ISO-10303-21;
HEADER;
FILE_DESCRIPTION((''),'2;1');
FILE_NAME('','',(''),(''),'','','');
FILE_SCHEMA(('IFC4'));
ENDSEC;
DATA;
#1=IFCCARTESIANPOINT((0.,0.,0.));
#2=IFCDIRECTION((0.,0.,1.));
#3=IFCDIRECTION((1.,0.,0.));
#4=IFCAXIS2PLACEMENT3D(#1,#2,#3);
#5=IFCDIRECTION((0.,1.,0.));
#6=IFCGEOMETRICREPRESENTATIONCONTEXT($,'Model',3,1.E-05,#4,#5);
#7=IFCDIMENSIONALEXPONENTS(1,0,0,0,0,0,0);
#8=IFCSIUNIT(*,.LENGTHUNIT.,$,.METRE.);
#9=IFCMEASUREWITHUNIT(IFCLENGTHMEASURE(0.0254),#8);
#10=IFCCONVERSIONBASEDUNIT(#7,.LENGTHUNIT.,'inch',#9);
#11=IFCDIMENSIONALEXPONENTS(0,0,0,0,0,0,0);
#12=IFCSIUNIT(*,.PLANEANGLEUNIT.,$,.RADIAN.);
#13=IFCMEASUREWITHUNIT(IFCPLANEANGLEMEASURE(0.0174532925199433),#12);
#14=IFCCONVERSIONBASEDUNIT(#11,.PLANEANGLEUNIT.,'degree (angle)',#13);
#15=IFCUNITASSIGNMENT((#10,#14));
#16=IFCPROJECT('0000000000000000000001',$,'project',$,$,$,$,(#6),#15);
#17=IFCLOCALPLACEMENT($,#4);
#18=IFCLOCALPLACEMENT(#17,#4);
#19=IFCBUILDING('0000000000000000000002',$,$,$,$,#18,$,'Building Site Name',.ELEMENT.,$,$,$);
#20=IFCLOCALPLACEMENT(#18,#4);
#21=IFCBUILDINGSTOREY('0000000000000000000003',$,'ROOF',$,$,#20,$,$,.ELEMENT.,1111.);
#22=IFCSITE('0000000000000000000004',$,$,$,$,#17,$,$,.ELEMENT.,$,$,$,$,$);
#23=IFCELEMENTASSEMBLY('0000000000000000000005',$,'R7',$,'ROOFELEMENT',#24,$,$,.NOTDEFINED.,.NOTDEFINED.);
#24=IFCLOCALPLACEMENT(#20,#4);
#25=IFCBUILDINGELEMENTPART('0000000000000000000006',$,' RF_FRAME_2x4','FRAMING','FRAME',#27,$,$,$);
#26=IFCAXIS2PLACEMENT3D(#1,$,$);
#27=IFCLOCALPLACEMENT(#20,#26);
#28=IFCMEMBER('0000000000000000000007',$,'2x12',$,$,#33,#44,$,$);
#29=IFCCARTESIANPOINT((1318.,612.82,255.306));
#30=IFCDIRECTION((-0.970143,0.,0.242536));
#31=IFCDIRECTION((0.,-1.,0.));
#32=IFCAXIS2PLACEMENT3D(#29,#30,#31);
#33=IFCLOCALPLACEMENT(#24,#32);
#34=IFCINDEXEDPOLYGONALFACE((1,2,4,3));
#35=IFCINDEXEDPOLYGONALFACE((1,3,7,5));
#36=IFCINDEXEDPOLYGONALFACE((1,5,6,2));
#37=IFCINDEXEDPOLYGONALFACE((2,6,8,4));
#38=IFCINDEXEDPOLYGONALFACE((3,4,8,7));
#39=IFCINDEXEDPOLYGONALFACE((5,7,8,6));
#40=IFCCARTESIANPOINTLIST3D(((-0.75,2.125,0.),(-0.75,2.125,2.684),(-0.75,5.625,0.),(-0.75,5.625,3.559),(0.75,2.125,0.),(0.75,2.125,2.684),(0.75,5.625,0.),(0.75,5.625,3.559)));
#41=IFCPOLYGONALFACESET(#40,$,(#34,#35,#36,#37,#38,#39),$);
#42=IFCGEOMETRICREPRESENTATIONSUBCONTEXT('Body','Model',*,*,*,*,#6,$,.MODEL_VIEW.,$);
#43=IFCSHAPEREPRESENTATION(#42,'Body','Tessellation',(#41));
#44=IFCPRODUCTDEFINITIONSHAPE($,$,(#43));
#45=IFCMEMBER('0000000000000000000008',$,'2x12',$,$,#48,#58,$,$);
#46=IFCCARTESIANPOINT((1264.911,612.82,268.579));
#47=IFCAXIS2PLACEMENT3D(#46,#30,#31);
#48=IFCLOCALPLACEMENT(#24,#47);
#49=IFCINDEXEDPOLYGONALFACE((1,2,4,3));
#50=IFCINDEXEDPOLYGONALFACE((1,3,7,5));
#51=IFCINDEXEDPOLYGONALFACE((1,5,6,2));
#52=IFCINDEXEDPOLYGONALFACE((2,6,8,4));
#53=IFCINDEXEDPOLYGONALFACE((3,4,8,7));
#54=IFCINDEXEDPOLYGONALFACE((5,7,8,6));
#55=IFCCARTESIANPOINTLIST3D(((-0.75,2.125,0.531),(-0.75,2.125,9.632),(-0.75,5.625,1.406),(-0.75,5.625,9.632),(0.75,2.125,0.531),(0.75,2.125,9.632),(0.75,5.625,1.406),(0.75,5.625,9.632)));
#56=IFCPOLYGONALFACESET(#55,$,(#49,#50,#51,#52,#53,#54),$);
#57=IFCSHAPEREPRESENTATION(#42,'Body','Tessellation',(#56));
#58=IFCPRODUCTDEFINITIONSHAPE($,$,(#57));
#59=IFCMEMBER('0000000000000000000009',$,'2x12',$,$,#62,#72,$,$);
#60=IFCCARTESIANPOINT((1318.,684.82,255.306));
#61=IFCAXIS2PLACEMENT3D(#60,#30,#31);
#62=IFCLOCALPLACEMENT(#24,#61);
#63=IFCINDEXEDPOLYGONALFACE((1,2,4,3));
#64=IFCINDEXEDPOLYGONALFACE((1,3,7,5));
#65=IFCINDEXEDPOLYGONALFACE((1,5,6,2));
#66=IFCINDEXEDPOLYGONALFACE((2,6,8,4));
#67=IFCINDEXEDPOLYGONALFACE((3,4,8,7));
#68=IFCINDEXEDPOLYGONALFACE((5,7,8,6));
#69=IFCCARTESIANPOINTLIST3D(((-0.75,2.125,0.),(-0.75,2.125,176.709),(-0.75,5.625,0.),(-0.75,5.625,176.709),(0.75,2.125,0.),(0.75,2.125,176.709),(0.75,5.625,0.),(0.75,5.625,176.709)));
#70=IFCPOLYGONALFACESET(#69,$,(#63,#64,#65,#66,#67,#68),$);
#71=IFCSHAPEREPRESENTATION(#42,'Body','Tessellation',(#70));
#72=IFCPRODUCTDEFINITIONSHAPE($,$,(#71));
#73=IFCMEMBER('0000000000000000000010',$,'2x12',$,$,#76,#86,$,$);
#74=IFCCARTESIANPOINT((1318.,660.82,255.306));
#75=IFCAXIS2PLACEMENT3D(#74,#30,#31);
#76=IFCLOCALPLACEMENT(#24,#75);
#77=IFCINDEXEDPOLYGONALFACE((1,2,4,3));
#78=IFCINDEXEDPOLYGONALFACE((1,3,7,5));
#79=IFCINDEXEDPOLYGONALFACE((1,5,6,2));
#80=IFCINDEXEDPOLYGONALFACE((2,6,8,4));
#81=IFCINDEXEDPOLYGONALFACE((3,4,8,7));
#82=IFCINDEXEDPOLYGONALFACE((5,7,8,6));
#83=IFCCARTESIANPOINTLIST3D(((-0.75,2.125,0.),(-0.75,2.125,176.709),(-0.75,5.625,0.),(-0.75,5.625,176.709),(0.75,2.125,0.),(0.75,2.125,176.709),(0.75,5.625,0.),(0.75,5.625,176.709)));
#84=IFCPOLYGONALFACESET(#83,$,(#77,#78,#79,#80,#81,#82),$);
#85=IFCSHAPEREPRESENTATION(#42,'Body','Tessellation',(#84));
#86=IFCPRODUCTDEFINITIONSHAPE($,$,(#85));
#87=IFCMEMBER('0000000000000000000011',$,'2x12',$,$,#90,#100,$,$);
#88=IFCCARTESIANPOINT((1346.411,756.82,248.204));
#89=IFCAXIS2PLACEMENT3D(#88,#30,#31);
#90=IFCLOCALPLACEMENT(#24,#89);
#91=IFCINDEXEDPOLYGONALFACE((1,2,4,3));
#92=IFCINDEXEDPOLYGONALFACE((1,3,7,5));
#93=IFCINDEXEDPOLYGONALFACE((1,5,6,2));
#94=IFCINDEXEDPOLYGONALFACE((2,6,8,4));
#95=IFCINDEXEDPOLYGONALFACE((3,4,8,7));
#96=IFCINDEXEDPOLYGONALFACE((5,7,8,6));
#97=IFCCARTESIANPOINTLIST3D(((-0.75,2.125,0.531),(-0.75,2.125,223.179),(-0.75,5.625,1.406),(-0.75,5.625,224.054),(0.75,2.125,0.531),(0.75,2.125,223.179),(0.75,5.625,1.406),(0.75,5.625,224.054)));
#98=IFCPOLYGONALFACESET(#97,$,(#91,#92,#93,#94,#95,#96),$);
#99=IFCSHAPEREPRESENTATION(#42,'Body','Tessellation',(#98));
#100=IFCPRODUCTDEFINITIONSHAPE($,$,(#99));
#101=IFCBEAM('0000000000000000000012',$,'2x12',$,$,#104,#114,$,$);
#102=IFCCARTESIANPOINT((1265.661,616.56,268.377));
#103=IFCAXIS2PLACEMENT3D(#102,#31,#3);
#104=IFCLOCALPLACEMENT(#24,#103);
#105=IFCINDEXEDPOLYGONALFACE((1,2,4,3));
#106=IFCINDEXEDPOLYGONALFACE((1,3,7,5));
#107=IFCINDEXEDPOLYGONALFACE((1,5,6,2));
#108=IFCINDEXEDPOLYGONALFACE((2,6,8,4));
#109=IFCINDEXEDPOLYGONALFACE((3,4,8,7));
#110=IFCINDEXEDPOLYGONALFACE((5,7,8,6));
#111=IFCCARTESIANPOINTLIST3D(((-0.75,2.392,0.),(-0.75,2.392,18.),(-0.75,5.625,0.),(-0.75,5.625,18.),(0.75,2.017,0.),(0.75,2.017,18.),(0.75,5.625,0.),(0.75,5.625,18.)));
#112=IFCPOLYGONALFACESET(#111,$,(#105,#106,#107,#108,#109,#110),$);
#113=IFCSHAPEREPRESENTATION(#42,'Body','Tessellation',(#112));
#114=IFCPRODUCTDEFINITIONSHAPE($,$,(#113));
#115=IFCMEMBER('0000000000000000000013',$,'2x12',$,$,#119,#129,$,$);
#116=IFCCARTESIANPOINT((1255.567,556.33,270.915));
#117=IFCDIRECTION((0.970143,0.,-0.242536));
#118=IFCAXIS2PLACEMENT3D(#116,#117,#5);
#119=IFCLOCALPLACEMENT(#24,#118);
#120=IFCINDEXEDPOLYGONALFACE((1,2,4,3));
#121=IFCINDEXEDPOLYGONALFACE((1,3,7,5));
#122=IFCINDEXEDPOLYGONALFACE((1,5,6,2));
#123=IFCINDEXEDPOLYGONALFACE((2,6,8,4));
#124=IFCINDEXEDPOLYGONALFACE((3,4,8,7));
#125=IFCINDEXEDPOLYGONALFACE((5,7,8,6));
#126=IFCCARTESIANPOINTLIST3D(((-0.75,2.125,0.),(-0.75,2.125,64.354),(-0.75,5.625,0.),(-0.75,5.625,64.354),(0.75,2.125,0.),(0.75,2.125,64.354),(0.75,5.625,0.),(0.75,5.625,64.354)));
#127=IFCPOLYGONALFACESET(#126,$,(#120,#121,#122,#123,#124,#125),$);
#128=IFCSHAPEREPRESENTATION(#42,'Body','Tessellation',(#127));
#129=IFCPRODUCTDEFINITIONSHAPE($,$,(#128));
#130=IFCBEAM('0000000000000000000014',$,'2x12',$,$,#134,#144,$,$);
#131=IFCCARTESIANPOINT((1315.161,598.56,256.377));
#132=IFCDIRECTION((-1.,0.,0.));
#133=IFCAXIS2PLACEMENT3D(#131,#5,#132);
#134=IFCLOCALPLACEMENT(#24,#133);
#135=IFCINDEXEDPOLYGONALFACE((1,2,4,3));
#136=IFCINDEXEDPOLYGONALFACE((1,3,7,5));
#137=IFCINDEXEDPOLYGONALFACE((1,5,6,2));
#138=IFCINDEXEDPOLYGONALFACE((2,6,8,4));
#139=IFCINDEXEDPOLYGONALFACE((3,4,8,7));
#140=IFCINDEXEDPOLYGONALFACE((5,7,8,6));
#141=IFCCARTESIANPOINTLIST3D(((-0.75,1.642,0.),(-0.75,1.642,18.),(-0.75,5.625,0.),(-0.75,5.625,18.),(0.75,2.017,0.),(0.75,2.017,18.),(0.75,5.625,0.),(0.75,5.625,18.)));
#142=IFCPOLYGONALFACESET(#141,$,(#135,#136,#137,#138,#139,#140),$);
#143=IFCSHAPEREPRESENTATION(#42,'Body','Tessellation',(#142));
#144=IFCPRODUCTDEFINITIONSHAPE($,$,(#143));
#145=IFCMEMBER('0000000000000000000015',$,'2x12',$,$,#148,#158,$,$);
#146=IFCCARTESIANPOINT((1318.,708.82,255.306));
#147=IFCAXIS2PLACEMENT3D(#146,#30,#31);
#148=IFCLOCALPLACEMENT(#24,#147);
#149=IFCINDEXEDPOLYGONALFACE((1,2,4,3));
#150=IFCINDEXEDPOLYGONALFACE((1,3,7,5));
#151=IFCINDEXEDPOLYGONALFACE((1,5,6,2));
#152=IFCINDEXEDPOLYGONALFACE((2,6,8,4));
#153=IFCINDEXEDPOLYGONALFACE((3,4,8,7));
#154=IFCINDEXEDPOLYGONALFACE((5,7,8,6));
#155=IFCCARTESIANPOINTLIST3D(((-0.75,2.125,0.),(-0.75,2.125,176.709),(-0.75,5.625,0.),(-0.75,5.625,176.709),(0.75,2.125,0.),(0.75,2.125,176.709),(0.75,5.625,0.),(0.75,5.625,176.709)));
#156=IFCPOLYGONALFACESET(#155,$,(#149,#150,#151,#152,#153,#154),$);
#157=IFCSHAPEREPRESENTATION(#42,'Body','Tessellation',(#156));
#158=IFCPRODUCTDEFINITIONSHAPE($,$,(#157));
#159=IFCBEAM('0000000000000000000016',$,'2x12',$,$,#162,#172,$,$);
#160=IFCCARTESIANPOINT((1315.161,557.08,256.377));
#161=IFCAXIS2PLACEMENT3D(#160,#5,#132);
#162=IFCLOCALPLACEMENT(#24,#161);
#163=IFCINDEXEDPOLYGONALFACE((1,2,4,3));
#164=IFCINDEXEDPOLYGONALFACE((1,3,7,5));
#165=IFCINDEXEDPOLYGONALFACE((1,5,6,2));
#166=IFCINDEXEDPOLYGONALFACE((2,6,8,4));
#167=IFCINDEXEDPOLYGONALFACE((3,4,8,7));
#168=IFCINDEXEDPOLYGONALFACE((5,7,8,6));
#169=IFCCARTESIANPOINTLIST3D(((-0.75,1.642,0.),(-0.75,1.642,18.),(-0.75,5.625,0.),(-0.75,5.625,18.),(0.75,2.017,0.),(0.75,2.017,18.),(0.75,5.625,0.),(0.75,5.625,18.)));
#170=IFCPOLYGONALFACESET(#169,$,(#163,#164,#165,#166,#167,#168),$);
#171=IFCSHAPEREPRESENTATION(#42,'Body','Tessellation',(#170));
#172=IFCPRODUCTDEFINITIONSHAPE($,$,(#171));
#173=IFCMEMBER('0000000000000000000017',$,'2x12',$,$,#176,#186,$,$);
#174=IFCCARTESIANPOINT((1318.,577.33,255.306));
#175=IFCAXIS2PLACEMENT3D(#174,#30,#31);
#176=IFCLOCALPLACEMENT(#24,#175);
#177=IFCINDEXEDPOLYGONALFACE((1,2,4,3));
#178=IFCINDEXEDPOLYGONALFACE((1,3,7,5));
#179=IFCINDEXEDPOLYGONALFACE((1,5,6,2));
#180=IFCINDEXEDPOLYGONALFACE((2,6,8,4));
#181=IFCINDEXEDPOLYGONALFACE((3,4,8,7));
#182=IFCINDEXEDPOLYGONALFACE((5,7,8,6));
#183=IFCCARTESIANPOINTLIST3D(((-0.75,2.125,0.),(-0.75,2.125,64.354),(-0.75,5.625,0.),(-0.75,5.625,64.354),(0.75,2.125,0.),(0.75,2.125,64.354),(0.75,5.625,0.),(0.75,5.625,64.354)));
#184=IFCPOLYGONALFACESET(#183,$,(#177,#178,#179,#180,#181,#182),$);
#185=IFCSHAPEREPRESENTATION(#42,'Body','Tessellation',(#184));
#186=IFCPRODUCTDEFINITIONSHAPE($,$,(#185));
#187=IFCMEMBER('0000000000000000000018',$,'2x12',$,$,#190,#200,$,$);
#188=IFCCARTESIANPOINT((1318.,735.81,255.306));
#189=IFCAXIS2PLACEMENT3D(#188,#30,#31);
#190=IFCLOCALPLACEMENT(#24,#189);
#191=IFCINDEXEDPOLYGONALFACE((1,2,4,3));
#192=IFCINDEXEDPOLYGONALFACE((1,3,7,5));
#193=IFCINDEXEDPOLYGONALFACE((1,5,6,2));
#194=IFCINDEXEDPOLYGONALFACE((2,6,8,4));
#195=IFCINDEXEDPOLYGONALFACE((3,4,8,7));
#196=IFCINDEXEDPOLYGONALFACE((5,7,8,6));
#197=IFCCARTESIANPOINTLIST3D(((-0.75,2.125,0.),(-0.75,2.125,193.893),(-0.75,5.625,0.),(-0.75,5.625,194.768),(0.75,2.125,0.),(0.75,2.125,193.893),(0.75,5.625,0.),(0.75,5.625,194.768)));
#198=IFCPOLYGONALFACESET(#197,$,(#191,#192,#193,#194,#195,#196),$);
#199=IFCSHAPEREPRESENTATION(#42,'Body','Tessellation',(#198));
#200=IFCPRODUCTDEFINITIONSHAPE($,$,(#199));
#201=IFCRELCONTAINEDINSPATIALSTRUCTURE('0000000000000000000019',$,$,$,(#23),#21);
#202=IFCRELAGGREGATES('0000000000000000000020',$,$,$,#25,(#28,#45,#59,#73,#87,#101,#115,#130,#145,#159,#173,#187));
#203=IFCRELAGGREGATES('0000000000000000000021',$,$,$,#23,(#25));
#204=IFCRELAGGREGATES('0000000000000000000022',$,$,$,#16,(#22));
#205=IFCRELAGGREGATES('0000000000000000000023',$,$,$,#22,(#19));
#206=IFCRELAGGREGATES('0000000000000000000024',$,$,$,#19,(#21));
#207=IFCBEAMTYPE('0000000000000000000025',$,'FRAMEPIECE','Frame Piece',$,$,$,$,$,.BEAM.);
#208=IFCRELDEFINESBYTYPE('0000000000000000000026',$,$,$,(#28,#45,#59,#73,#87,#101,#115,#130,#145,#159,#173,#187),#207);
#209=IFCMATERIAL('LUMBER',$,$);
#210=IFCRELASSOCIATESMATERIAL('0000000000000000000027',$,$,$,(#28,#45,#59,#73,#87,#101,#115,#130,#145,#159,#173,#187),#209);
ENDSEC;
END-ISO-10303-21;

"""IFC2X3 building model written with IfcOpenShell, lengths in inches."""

from ifc_helpers import new_model, entity, si_unit, converted_unit, direction, frame, frame_2d, origin_with_axes, place, context, subcontext, project, spatial, polyline, segment, composite_curve, rectangle, outline, extrude, clip, halfspace, material, type_object, element, aggregate, save


model = new_model("IFC2X3")

# Units and contexts
model_context = context("Model", 3, precision=1e-05, world=origin_with_axes(), true_north=direction((0.0, 1.0, 0.0)))
body_context = subcontext(model_context, "Body", "Model", "MODEL_VIEW")
ifc_project = project(units=[converted_unit("LENGTHUNIT", "inch", entity("IfcLengthMeasure", 0.0254), si_unit("LENGTHUNIT", "METRE"), dimensions=[1, 0, 0, 0, 0, 0, 0]), converted_unit("PLANEANGLEUNIT", "degree (angle)", entity("IfcPlaneAngleMeasure", 0.0174532925199433), si_unit("PLANEANGLEUNIT", "RADIAN"), dimensions=[0, 0, 0, 0, 0, 0, 0])], contexts=[model_context])

# Site, building, storey
site_placement = place(None, origin_with_axes())
site = spatial("IfcSite", under=ifc_project, at=site_placement, CompositionType="ELEMENT")
building_placement = place(site_placement, origin_with_axes())
building = spatial("IfcBuilding", under=site, at=building_placement, LongName="Building Site Name", CompositionType="ELEMENT")
storey_placement = place(building_placement, origin_with_axes())
storey = spatial("IfcBuildingStorey", under=building, at=storey_placement, Name="ROOF", CompositionType="ELEMENT", Elevation=1111.0)

# Element assembly, building element part, members, beams
assembly_placement = place(storey_placement, origin_with_axes())
assembly = element("IfcElementAssembly", 1, at=assembly_placement, inside=storey, Name="R7", ObjectType="ROOFELEMENT", AssemblyPlace="NOTDEFINED", PredefinedType="NOTDEFINED")
building_element_part_1 = element("IfcBuildingElementPart", 2, Name=" RF_FRAME_2x4", Description="FRAMING", ObjectType="FRAME")
ifc_material_1 = material(Name="LUMBER")
beam_type = type_object("IfcBeamType", Name="FRAMEPIECE", Description="Frame Piece", PredefinedType="BEAM")
member_1_placement = place(assembly_placement, frame((1318.0, 612.82, 255.306), z_axis=(-0.970143, 0.0, 0.242536), x_axis=(0.0, -1.0, 0.0)))
member_1 = element("IfcMember", 3, at=member_1_placement, type_object=beam_type, material=ifc_material_1, Name="2x12", context=body_context, shape_type="Clipping", body=[
    clip(extrude(rectangle(XDim=3.5, YDim=1.5, at=frame_2d((0.0, 3.875), x_axis=(0.0, -1.0))), frame((0.0, 0.0, 0.0), z_axis=(0.0, 0.0, 1.0), x_axis=(1.0, 0.0, 0.0)), (0.0, 0.0, 1.0), 5.338), halfspace(frame((-0.75, 2.125, 2.684), z_axis=(0.0, 0.242536, -0.970143), x_axis=(0.0, -0.970143, -0.242536)), True)),
])
member_2_placement = place(assembly_placement, frame((1264.911, 612.82, 268.579), z_axis=(-0.970143, 0.0, 0.242536), x_axis=(0.0, -1.0, 0.0)))
member_2 = element("IfcMember", 4, at=member_2_placement, type_object=beam_type, material=ifc_material_1, Name="2x12", context=body_context, shape_type="Clipping", body=[
    clip(extrude(rectangle(XDim=3.5, YDim=1.5, at=frame_2d((0.0, 3.875), x_axis=(0.0, -1.0))), frame((0.0, 0.0, -4.019), z_axis=(0.0, 0.0, 1.0), x_axis=(1.0, 0.0, 0.0)), (0.0, 0.0, 1.0), 13.651), halfspace(frame((0.75, 2.125, 0.531), z_axis=(0.0, -0.242536, 0.970143), x_axis=(0.0, 0.970143, 0.242536)), True)),
])
member_3_placement = place(assembly_placement, frame((1318.0, 684.82, 255.306), z_axis=(-0.970143, 0.0, 0.242536), x_axis=(0.0, -1.0, 0.0)))
member_3 = element("IfcMember", 5, at=member_3_placement, type_object=beam_type, material=ifc_material_1, Name="2x12", context=body_context, shape_type="SweptSolid", body=[
    extrude(rectangle(XDim=3.5, YDim=1.5, at=frame_2d((0.0, 3.875), x_axis=(0.0, -1.0))), frame((0.0, 0.0, 0.0), z_axis=(0.0, 0.0, 1.0), x_axis=(1.0, 0.0, 0.0)), (0.0, 0.0, 1.0), 176.709),
])
member_4_placement = place(assembly_placement, frame((1318.0, 660.82, 255.306), z_axis=(-0.970143, 0.0, 0.242536), x_axis=(0.0, -1.0, 0.0)))
member_4 = element("IfcMember", 6, at=member_4_placement, type_object=beam_type, material=ifc_material_1, Name="2x12", context=body_context, shape_type="SweptSolid", body=[
    extrude(rectangle(XDim=3.5, YDim=1.5, at=frame_2d((0.0, 3.875), x_axis=(0.0, -1.0))), frame((0.0, 0.0, 0.0), z_axis=(0.0, 0.0, 1.0), x_axis=(1.0, 0.0, 0.0)), (0.0, 0.0, 1.0), 176.709),
])
member_5_placement = place(assembly_placement, frame((1346.411, 756.82, 248.204), z_axis=(-0.970143, 0.0, 0.242536), x_axis=(0.0, -1.0, 0.0)))
member_5 = element("IfcMember", 7, at=member_5_placement, type_object=beam_type, material=ifc_material_1, Name="2x12", context=body_context, shape_type="Clipping", body=[
    clip(clip(extrude(rectangle(XDim=3.5, YDim=1.5, at=frame_2d((0.0, 3.875), x_axis=(0.0, -1.0))), frame((0.0, 0.0, -111.23), z_axis=(0.0, 0.0, 1.0), x_axis=(1.0, 0.0, 0.0)), (0.0, 0.0, 1.0), 447.045), halfspace(frame((0.75, 2.125, 0.531), z_axis=(0.0, -0.242536, 0.970143), x_axis=(0.0, 0.970143, 0.242536)), True)), halfspace(frame((-0.75, 2.125, 223.179), z_axis=(0.0, 0.242536, -0.970143), x_axis=(0.0, -0.970143, -0.242536)), True)),
])
beam_1_placement = place(assembly_placement, frame((1265.661, 616.56, 268.377), z_axis=(0.0, -1.0, 0.0), x_axis=(1.0, 0.0, 0.0)))
beam_1 = element("IfcBeam", 8, at=beam_1_placement, type_object=beam_type, material=ifc_material_1, Name="2x12", context=body_context, shape_type="SweptSolid", body=[
    extrude(outline(composite_curve([segment(polyline([(-0.75, 2.392), (0.75, 2.017), (0.75, 5.625), (-0.75, 5.625), (-0.75, 2.392)]), True, "CONTINUOUS")], self_intersect=False)), origin_with_axes(), (0.0, 0.0, 1.0), 18.0),
])
member_6_placement = place(assembly_placement, frame((1255.567, 556.33, 270.915), z_axis=(0.970143, 0.0, -0.242536), x_axis=(0.0, 1.0, 0.0)))
member_6 = element("IfcMember", 9, at=member_6_placement, type_object=beam_type, material=ifc_material_1, Name="2x12", context=body_context, shape_type="SweptSolid", body=[
    extrude(rectangle(XDim=3.5, YDim=1.5, at=frame_2d((0.0, 3.875), x_axis=(0.0, -1.0))), frame((0.0, 0.0, 0.0), z_axis=(0.0, 0.0, 1.0), x_axis=(1.0, 0.0, 0.0)), (0.0, 0.0, 1.0), 64.354),
])
beam_2_placement = place(assembly_placement, frame((1315.161, 598.56, 256.377), z_axis=(0.0, 1.0, 0.0), x_axis=(-1.0, 0.0, 0.0)))
beam_2 = element("IfcBeam", 10, at=beam_2_placement, type_object=beam_type, material=ifc_material_1, Name="2x12", context=body_context, shape_type="SweptSolid", body=[
    extrude(outline(composite_curve([segment(polyline([(-0.75, 1.642), (0.75, 2.017), (0.75, 5.625), (-0.75, 5.625), (-0.75, 1.642)]), True, "CONTINUOUS")], self_intersect=False)), origin_with_axes(), (0.0, 0.0, 1.0), 18.0),
])
member_7_placement = place(assembly_placement, frame((1318.0, 708.82, 255.306), z_axis=(-0.970143, 0.0, 0.242536), x_axis=(0.0, -1.0, 0.0)))
member_7 = element("IfcMember", 11, at=member_7_placement, type_object=beam_type, material=ifc_material_1, Name="2x12", context=body_context, shape_type="SweptSolid", body=[
    extrude(rectangle(XDim=3.5, YDim=1.5, at=frame_2d((0.0, 3.875), x_axis=(0.0, -1.0))), frame((0.0, 0.0, 0.0), z_axis=(0.0, 0.0, 1.0), x_axis=(1.0, 0.0, 0.0)), (0.0, 0.0, 1.0), 176.709),
])
beam_3_placement = place(assembly_placement, frame((1315.161, 557.08, 256.377), z_axis=(0.0, 1.0, 0.0), x_axis=(-1.0, 0.0, 0.0)))
beam_3 = element("IfcBeam", 12, at=beam_3_placement, type_object=beam_type, material=ifc_material_1, Name="2x12", context=body_context, shape_type="SweptSolid", body=[
    extrude(outline(composite_curve([segment(polyline([(-0.75, 1.642), (0.75, 2.017), (0.75, 5.625), (-0.75, 5.625), (-0.75, 1.642)]), True, "CONTINUOUS")], self_intersect=False)), origin_with_axes(), (0.0, 0.0, 1.0), 18.0),
])
member_8_placement = place(assembly_placement, frame((1318.0, 577.33, 255.306), z_axis=(-0.970143, 0.0, 0.242536), x_axis=(0.0, -1.0, 0.0)))
member_8 = element("IfcMember", 13, at=member_8_placement, type_object=beam_type, material=ifc_material_1, Name="2x12", context=body_context, shape_type="SweptSolid", body=[
    extrude(rectangle(XDim=3.5, YDim=1.5, at=frame_2d((0.0, 3.875), x_axis=(0.0, -1.0))), frame((0.0, 0.0, 0.0), z_axis=(0.0, 0.0, 1.0), x_axis=(1.0, 0.0, 0.0)), (0.0, 0.0, 1.0), 64.354),
])
member_9_placement = place(assembly_placement, frame((1318.0, 735.81, 255.306), z_axis=(-0.970143, 0.0, 0.242536), x_axis=(0.0, -1.0, 0.0)))
member_9 = element("IfcMember", 14, at=member_9_placement, type_object=beam_type, material=ifc_material_1, Name="2x12", context=body_context, shape_type="Clipping", body=[
    clip(extrude(rectangle(XDim=3.5, YDim=1.5, at=frame_2d((0.0, 3.875), x_axis=(0.0, -1.0))), frame((0.0, 0.0, 0.0), z_axis=(0.0, 0.0, 1.0), x_axis=(1.0, 0.0, 0.0)), (0.0, 0.0, 1.0), 292.152), halfspace(frame((-0.75, 2.125, 193.893), z_axis=(0.0, 0.242536, -0.970143), x_axis=(0.0, -0.970143, -0.242536)), True)),
])
aggregate(building_element_part_1, [member_1, member_2, member_3, member_4, member_5, beam_1, member_6, beam_2, member_7, beam_3, member_8, member_9])
aggregate(assembly, [building_element_part_1])

save(model, "model.ifc")
